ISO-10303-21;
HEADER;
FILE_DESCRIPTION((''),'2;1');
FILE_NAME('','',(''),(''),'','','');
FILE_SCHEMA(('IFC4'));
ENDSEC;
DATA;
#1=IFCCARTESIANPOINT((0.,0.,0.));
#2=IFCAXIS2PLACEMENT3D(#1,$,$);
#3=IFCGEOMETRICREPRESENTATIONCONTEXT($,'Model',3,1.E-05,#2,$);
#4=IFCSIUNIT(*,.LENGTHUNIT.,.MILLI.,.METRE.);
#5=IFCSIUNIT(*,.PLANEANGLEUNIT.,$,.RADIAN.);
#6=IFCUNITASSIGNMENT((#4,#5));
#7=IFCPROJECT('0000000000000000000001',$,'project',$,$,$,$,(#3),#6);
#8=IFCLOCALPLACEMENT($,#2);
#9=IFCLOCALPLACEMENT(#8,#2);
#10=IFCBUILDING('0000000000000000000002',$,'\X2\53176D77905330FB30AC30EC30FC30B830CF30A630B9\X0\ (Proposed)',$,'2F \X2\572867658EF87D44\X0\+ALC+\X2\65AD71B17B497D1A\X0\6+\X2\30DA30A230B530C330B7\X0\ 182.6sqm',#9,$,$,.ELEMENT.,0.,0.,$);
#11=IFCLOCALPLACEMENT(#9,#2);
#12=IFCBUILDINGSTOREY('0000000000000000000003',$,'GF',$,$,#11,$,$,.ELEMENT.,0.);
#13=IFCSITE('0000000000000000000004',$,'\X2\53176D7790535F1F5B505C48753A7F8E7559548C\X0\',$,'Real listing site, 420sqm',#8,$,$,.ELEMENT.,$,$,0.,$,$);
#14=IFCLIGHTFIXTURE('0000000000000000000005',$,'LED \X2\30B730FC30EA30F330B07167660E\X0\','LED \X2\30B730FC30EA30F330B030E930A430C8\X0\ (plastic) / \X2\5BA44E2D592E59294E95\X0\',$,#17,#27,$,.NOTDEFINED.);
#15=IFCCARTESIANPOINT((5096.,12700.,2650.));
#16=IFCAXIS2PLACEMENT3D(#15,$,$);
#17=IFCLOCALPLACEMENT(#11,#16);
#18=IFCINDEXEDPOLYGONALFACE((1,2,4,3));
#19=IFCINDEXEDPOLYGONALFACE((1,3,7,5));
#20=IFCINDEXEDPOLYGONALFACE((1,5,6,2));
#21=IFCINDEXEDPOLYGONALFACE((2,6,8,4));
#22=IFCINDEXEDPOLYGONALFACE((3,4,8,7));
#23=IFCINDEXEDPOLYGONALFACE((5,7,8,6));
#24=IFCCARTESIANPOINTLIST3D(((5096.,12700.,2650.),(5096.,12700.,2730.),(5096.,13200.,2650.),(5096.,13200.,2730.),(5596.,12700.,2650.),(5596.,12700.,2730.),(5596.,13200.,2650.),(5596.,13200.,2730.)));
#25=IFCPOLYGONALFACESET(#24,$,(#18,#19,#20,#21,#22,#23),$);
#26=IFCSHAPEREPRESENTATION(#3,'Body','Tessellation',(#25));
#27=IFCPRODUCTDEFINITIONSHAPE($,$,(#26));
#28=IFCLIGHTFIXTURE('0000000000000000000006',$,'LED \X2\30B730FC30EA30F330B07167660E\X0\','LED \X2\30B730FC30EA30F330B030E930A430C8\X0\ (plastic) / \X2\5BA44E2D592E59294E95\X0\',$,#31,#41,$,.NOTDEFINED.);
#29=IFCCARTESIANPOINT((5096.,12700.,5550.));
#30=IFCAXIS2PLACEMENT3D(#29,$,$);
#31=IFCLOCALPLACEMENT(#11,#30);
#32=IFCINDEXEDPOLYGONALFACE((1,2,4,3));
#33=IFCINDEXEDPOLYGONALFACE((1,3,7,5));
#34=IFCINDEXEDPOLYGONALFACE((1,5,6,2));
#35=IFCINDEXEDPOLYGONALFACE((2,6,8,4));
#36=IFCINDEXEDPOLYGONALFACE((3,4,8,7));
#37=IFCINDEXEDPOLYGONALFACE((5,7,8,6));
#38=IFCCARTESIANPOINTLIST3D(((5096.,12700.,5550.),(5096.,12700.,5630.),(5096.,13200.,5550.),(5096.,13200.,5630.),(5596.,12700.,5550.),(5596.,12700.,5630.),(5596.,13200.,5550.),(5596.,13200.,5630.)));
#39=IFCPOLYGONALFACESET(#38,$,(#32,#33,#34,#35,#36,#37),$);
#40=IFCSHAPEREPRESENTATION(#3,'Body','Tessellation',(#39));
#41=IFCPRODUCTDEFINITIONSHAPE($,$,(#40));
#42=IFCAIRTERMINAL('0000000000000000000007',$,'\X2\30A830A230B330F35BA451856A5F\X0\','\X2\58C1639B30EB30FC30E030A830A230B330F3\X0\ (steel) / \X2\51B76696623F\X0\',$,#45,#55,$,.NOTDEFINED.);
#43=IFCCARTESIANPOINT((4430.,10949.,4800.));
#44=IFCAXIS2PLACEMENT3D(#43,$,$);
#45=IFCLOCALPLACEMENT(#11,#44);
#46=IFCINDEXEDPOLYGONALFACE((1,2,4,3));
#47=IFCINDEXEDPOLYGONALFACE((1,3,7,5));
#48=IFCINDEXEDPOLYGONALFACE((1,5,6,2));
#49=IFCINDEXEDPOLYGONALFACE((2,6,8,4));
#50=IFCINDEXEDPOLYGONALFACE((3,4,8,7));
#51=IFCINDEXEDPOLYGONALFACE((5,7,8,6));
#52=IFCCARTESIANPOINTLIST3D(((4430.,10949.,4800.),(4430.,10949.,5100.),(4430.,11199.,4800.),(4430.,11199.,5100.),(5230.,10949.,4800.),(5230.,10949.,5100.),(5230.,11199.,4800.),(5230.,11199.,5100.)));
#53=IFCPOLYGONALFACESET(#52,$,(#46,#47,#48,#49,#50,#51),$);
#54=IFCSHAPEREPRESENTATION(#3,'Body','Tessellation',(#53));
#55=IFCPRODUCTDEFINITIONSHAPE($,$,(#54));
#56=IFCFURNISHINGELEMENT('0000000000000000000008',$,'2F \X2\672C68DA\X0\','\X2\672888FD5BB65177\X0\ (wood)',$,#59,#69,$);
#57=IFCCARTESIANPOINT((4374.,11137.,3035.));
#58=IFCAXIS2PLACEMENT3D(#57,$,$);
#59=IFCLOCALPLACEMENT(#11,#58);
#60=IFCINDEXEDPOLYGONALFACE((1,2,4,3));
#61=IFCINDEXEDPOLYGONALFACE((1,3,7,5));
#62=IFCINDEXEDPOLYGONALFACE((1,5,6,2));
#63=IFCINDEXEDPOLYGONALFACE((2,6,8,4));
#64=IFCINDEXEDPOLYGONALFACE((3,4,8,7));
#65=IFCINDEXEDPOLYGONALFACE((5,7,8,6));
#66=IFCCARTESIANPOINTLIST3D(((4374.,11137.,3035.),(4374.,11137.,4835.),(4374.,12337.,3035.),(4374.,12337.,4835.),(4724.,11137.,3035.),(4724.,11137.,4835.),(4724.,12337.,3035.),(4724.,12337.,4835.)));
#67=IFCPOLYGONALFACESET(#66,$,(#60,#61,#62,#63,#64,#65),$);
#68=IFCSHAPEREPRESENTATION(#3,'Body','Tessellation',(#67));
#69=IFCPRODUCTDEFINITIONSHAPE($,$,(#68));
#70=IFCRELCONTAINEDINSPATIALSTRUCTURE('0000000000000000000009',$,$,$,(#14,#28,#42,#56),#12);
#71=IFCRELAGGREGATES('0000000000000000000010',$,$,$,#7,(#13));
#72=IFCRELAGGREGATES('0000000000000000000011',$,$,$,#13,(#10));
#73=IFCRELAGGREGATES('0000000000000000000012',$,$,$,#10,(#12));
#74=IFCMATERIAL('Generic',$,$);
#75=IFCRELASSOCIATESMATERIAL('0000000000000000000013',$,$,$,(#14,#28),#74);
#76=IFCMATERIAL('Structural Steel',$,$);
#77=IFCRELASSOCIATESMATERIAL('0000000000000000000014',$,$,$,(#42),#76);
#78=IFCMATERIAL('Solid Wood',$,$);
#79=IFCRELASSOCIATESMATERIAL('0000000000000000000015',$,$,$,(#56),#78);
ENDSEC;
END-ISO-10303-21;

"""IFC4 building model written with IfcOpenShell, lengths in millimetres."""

from ifc_helpers import new_model, si_unit, frame, frame_2d, origin, place, context, project, spatial, rectangle, extrude, material, element, save


model = new_model("IFC4")

# Units and contexts
model_context = context("Model", 3, precision=1e-05, world=origin())
ifc_project = project(units=[si_unit("LENGTHUNIT", "METRE", prefix="MILLI"), si_unit("PLANEANGLEUNIT", "RADIAN")], contexts=[model_context])

# Site, building, storey
site_placement = place(None, origin())
site = spatial("IfcSite", under=ifc_project, at=site_placement, Name="北海道弟子屈町美留和", ObjectType="Real listing site, 420sqm", CompositionType="ELEMENT", RefElevation=0.0)
building_placement = place(site_placement, origin())
building = spatial("IfcBuilding", under=site, at=building_placement, Name="北海道・ガレージハウス (Proposed)", ObjectType="2F 在来軸組+ALC+断熱等級6+ペアサッシ 182.6sqm", CompositionType="ELEMENT", ElevationOfRefHeight=0.0, ElevationOfTerrain=0.0)
storey_placement = place(building_placement, origin())
storey = spatial("IfcBuildingStorey", under=building, at=storey_placement, Name="GF", CompositionType="ELEMENT", Elevation=0.0)

# Shared definitions
ifc_material_1 = material(Name="Solid Wood")

# Shared definitions
ifc_material_2 = material(Name="Structural Steel")

# Shared definitions
ifc_material_3 = material(Name="Generic")

# Light fixtures
light_fixture_1_placement = place(storey_placement, frame((5096.0, 12700.0, 2650.0)))
element("IfcLightFixture", 1, at=light_fixture_1_placement, inside=storey, material=ifc_material_3, Name="LED シーリング照明", Description="LED シーリングライト (plastic) / 室中央天井", PredefinedType="NOTDEFINED", context=model_context, shape_type="SweptSolid", body=[
    extrude(rectangle(XDim=500.0, YDim=500.0, at=frame_2d((250.0, 250.0))), frame((5096.0, 12700.0, 2650.0)), (0.0, 0.0, 1.0), 80.0),
])
light_fixture_2_placement = place(storey_placement, frame((5096.0, 12700.0, 5550.0)))
element("IfcLightFixture", 2, at=light_fixture_2_placement, inside=storey, material=ifc_material_3, Name="LED シーリング照明", Description="LED シーリングライト (plastic) / 室中央天井", PredefinedType="NOTDEFINED", context=model_context, shape_type="SweptSolid", body=[
    extrude(rectangle(XDim=500.0, YDim=500.0, at=frame_2d((250.0, 250.0))), frame((5096.0, 12700.0, 5550.0)), (0.0, 0.0, 1.0), 80.0),
])

# Air terminal
air_terminal_placement = place(storey_placement, frame((4430.0, 10949.0, 4800.0)))
element("IfcAirTerminal", 3, at=air_terminal_placement, inside=storey, material=ifc_material_2, Name="エアコン室内機", Description="壁掛ルームエアコン (steel) / 冷暖房", PredefinedType="NOTDEFINED", context=model_context, shape_type="SweptSolid", body=[
    extrude(rectangle(XDim=800.0, YDim=250.0, at=frame_2d((400.0, 125.0))), frame((4430.0, 10949.0, 4800.0)), (0.0, 0.0, 1.0), 300.0),
])

# Furnishing element
furnishing_placement = place(storey_placement, frame((4374.0, 11137.0, 3035.0)))
element("IfcFurnishingElement", 4, at=furnishing_placement, inside=storey, material=ifc_material_1, Name="2F 本棚", Description="木製家具 (wood)", context=model_context, shape_type="SweptSolid", body=[
    extrude(rectangle(XDim=350.0, YDim=1200.0, at=frame_2d((175.0, 600.0))), frame((4374.0, 11137.0, 3035.0)), (0.0, 0.0, 1.0), 1800.0),
])

save(model, "model.ifc")
